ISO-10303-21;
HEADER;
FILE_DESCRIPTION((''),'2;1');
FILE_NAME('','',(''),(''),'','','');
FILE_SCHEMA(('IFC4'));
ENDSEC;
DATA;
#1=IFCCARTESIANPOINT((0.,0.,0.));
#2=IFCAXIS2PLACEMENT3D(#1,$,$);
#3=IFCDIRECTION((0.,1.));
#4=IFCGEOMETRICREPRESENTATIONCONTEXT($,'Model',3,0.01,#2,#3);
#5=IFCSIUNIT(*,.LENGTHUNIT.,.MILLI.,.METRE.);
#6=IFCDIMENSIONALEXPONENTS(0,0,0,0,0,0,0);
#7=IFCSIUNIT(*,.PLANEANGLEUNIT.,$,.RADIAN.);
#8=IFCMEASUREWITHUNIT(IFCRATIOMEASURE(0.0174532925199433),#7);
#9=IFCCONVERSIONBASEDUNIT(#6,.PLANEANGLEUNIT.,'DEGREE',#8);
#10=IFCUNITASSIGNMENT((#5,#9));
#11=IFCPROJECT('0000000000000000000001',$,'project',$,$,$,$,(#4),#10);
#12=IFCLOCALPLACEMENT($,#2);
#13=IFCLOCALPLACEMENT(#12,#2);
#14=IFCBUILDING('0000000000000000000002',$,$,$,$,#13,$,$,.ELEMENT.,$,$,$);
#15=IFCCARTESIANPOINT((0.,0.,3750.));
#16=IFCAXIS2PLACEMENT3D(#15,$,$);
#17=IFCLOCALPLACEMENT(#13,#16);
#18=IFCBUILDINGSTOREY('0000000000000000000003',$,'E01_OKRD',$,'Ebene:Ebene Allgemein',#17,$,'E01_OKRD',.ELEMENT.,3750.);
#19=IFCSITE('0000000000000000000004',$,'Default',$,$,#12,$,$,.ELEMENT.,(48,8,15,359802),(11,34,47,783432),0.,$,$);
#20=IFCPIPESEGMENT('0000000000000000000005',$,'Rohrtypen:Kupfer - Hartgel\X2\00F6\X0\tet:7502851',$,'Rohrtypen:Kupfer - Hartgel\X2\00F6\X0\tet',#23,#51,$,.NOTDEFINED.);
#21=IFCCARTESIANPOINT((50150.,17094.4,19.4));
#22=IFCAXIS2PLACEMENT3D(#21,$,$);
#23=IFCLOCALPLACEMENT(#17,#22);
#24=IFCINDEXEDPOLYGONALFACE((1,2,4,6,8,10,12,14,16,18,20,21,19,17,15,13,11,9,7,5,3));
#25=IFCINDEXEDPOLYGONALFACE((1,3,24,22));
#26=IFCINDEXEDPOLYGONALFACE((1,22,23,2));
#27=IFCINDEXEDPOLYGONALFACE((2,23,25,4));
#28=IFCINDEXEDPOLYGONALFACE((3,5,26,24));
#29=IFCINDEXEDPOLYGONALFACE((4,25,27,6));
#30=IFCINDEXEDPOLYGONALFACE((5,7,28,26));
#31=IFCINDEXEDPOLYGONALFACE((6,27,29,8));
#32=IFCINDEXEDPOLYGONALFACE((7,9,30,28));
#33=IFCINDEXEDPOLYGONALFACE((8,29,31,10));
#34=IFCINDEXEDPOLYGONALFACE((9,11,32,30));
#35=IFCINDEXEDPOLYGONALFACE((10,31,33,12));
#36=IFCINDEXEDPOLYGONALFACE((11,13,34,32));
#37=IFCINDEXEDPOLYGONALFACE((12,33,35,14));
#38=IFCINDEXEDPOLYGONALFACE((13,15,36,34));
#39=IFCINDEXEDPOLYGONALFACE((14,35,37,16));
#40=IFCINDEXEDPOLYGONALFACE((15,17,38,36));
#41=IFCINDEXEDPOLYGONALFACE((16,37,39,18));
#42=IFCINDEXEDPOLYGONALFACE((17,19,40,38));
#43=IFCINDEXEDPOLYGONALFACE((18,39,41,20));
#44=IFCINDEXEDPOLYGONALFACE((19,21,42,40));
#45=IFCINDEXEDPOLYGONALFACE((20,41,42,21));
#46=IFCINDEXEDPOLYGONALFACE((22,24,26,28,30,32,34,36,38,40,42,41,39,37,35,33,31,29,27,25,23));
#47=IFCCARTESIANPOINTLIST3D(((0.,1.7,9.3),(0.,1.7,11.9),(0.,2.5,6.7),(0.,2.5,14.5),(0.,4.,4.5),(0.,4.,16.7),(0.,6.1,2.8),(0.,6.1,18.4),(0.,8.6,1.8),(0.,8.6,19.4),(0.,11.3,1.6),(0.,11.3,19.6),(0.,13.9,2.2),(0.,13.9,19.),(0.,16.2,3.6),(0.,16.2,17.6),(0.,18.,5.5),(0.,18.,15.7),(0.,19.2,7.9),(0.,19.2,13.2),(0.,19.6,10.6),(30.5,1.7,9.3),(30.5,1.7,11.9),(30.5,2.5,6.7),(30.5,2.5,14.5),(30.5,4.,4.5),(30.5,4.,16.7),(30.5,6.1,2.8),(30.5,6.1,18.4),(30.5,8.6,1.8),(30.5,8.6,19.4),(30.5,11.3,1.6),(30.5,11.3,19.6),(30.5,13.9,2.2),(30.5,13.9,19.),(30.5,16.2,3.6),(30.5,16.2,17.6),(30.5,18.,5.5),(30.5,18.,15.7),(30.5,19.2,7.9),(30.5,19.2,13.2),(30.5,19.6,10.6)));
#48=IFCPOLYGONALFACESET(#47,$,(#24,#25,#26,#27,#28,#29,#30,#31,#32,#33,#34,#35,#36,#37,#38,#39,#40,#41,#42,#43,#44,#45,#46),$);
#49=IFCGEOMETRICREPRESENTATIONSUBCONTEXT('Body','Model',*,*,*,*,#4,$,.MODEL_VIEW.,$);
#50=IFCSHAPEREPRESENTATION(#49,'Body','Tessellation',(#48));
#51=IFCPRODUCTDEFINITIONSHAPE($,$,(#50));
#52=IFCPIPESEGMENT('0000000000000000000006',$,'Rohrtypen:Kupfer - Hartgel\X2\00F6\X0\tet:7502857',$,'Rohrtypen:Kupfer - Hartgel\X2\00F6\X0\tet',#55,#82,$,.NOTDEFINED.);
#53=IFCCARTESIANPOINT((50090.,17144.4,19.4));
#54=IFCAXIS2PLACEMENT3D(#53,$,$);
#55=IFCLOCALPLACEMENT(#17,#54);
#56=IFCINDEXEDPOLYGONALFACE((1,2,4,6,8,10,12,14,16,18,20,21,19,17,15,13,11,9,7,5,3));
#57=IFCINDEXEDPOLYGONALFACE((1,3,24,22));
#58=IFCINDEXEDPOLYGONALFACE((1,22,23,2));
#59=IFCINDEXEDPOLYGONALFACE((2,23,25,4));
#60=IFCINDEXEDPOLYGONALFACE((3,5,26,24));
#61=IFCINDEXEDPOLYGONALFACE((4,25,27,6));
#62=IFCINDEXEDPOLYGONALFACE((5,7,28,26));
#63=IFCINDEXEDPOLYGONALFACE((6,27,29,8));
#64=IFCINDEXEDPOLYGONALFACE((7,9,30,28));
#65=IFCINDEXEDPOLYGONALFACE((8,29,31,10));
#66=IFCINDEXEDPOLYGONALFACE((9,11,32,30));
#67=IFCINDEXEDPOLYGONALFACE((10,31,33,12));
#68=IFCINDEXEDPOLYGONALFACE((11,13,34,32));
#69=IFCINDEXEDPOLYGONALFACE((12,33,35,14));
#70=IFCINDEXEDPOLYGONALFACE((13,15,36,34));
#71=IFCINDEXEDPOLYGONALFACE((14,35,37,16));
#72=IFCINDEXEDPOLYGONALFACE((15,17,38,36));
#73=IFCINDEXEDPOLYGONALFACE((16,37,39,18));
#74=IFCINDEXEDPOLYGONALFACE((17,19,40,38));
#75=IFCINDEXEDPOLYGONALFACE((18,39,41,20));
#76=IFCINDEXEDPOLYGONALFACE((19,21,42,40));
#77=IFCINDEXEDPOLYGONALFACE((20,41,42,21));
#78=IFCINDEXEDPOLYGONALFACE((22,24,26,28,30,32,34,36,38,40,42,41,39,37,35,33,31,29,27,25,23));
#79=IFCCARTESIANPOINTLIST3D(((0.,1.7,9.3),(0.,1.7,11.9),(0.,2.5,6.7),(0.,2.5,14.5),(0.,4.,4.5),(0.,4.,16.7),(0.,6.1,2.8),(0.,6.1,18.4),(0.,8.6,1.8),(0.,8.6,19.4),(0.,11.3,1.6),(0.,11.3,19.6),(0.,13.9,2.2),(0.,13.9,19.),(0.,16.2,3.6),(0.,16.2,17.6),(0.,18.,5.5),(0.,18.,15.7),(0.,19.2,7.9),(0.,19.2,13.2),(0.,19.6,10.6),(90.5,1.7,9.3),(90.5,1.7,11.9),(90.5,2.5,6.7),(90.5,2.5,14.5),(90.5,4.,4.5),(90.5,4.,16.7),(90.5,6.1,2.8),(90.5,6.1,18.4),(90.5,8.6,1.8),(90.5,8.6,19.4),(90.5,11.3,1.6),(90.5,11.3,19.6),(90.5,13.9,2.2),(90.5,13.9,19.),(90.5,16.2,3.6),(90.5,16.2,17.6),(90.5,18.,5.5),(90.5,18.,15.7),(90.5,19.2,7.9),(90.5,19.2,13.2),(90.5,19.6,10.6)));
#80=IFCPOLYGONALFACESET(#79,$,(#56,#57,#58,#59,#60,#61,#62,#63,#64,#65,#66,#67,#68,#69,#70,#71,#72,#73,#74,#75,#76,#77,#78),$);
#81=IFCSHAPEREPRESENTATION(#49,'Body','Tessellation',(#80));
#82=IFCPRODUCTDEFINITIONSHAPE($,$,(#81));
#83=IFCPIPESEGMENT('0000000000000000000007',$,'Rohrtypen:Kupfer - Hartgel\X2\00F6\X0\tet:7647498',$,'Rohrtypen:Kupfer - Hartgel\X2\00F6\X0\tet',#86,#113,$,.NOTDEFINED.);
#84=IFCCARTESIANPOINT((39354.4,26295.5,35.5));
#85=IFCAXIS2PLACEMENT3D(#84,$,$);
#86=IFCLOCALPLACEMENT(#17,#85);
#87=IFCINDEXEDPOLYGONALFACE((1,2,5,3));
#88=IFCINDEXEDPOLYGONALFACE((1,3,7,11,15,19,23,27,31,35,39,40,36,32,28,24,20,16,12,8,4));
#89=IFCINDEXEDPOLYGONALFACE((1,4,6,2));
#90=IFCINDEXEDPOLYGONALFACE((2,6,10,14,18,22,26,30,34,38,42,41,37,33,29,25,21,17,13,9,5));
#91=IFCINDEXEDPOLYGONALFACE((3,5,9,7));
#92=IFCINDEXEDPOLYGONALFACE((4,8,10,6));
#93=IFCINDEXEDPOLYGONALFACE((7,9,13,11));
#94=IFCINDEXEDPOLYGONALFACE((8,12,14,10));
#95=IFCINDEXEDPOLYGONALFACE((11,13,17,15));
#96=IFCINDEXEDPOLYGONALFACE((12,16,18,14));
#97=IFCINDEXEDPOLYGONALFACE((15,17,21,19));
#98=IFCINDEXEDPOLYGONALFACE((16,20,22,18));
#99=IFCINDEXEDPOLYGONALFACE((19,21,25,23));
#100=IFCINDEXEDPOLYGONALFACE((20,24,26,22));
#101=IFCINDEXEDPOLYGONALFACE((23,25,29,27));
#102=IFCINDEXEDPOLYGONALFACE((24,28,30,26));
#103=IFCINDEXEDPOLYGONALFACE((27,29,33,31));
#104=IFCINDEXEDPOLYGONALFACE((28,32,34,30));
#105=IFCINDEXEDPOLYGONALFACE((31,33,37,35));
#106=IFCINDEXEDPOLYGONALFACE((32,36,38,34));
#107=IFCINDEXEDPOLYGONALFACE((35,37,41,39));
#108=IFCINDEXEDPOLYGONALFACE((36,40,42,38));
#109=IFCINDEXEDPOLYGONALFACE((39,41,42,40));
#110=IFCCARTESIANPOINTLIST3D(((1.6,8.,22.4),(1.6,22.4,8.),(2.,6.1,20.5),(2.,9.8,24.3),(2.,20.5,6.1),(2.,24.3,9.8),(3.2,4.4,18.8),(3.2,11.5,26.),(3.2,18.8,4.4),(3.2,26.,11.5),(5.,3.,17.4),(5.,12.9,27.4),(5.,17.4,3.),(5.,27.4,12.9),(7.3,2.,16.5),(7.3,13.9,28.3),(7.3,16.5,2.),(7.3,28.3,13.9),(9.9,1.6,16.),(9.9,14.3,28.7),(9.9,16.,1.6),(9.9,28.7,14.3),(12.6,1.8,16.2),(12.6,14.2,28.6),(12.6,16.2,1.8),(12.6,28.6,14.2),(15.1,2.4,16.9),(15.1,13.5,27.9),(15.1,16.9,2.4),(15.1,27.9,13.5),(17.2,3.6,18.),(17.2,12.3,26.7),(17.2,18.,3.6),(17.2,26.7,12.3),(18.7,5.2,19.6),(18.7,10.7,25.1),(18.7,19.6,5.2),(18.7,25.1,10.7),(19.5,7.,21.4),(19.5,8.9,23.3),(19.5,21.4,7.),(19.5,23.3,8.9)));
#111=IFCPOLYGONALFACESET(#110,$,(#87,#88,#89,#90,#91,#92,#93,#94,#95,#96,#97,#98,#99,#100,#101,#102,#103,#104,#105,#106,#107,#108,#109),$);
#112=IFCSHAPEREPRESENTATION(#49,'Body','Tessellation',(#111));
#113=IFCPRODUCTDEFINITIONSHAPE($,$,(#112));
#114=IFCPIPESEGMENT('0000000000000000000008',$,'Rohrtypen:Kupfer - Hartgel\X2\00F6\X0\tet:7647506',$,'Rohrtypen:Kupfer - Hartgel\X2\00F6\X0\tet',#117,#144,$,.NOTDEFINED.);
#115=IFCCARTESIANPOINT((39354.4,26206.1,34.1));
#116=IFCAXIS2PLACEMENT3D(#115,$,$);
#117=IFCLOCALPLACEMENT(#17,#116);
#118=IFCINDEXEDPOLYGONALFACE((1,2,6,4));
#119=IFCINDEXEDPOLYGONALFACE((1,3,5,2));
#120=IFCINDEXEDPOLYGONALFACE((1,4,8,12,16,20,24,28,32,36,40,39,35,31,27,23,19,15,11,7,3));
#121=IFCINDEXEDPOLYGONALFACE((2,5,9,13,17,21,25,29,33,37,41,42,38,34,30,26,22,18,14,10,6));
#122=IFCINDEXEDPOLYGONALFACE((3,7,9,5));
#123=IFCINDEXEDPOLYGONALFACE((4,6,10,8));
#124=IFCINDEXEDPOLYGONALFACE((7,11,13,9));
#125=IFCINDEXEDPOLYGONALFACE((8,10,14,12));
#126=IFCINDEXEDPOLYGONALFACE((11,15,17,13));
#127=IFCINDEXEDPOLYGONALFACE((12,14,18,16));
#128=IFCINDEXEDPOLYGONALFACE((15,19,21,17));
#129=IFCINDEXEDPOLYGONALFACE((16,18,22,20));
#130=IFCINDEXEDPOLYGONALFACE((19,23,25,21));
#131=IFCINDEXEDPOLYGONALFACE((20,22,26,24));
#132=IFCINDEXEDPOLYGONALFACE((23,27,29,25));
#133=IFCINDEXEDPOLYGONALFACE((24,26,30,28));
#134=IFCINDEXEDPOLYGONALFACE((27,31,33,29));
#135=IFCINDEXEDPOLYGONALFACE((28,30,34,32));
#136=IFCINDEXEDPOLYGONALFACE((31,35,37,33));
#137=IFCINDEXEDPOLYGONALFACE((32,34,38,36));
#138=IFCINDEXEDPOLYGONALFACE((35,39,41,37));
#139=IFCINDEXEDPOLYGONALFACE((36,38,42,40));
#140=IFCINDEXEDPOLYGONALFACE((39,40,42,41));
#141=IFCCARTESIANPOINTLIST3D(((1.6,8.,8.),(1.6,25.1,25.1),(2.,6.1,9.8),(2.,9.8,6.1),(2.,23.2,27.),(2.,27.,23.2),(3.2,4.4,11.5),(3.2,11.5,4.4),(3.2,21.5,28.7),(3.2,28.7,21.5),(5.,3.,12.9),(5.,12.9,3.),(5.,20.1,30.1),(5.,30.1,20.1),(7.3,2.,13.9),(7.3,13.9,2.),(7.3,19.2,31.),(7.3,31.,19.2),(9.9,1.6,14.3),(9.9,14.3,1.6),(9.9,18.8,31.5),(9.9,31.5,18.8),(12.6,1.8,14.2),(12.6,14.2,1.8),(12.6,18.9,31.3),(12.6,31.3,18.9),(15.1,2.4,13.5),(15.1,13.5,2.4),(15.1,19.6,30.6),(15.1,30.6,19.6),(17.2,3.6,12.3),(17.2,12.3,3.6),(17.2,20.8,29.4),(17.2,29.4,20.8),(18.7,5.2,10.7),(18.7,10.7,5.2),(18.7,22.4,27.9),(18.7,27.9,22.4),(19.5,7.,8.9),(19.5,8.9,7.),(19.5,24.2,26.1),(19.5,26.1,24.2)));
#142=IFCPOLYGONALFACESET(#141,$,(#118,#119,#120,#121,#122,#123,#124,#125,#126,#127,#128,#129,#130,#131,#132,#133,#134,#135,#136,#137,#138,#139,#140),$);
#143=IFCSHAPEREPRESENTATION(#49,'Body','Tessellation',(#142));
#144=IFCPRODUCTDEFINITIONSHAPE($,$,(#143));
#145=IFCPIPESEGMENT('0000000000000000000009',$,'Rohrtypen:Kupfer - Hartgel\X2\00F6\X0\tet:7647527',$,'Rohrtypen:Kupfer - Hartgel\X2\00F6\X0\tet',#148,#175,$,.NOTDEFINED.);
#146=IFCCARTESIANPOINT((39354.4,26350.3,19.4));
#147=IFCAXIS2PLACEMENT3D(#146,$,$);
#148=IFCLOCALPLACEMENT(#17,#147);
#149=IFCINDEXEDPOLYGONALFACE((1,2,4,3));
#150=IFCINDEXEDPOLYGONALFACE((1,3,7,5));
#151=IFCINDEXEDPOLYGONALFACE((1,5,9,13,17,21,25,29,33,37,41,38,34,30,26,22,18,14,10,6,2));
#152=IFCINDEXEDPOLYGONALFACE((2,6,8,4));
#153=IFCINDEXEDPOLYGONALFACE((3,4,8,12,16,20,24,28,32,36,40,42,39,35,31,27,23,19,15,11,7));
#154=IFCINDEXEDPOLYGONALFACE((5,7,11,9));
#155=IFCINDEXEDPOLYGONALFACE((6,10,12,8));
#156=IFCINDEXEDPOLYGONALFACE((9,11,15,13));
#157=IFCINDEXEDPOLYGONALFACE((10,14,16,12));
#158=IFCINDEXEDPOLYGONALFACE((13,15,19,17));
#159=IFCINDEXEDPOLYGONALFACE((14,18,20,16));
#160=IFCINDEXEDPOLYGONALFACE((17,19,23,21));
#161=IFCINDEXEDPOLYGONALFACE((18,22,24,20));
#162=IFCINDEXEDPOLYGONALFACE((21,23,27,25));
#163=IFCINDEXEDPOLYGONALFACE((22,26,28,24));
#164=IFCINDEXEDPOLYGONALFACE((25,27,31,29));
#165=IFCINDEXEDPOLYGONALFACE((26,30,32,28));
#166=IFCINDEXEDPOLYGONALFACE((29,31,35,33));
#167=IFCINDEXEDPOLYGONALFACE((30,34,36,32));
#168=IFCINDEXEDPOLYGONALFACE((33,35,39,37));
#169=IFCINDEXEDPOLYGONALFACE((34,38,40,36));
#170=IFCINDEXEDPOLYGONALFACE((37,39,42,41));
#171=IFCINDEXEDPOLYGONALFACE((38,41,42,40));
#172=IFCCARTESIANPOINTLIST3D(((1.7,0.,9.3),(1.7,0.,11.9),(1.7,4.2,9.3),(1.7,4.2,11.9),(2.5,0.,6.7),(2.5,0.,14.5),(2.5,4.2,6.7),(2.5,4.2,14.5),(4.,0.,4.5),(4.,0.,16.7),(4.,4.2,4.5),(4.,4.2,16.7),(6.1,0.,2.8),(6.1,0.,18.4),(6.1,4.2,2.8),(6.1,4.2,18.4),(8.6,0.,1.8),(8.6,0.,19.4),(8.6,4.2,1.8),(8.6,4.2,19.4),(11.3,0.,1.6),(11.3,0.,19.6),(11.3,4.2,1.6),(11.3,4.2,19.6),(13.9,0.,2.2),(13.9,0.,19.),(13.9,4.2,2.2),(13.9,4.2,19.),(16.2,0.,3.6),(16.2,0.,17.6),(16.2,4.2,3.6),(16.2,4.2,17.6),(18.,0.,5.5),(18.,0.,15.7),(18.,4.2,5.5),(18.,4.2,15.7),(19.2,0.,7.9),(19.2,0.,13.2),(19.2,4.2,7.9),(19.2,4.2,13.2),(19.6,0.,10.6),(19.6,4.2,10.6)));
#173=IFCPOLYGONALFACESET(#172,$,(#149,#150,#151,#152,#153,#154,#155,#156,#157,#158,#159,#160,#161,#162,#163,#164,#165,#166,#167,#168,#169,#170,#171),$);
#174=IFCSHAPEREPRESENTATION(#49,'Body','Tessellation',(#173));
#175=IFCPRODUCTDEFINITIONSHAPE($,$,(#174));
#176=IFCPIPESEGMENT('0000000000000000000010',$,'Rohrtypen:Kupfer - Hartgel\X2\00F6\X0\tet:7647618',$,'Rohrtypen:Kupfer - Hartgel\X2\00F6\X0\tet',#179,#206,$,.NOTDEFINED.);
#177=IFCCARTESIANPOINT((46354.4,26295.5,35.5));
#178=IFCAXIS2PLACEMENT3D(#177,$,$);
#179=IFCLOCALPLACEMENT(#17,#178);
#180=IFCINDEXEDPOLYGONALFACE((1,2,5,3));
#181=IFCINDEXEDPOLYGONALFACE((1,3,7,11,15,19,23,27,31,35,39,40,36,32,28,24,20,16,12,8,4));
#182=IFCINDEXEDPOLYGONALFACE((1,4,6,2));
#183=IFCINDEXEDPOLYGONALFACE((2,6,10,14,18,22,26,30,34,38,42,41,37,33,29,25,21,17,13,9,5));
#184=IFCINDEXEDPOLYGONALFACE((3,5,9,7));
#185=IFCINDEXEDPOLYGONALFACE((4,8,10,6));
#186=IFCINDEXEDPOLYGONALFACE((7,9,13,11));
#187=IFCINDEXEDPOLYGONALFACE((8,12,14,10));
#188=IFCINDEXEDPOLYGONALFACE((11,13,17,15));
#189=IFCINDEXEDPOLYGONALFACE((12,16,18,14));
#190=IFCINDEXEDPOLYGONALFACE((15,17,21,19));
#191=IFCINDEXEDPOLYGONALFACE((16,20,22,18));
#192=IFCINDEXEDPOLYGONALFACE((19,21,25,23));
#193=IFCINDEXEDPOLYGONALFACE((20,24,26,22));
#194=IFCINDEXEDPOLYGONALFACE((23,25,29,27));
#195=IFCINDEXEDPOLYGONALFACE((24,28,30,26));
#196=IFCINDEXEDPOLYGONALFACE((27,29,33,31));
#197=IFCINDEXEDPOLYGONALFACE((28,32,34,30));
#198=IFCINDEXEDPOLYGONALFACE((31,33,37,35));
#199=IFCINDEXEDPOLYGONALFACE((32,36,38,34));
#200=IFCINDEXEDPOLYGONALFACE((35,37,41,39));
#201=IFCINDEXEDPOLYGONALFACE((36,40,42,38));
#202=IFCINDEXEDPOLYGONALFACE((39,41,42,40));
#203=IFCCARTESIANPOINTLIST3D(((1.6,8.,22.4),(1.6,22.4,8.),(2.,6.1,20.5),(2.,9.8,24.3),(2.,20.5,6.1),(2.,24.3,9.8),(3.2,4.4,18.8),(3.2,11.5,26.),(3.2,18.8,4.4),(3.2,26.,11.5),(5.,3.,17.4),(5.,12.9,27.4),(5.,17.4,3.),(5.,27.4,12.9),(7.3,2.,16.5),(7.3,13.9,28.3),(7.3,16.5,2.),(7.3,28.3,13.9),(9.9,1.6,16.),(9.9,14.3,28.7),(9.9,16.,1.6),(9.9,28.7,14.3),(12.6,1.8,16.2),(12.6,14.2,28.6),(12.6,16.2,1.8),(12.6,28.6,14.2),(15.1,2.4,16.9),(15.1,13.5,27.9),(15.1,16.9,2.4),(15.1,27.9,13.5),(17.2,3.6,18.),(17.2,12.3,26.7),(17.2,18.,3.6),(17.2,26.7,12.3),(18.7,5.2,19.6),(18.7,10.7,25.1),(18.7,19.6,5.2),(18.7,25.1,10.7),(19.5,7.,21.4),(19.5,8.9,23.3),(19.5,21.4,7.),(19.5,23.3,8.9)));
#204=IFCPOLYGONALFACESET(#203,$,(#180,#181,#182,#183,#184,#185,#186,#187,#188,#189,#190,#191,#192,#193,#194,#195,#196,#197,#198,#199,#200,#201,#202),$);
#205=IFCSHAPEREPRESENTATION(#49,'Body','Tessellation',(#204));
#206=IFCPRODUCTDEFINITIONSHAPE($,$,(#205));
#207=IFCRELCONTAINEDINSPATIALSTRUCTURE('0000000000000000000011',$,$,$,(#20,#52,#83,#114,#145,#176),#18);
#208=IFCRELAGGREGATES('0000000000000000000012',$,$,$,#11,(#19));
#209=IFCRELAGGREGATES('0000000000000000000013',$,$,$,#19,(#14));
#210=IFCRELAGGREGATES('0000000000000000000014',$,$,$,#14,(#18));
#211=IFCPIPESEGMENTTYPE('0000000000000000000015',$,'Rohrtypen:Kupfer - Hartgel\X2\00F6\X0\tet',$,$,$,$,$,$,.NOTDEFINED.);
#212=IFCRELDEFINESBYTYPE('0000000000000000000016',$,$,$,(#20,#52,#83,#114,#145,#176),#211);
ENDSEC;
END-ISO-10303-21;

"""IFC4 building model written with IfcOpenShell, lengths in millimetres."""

from ifc_helpers import new_model, entity, si_unit, converted_unit, direction, frame, frame_2d, origin, origin_2d_with_axis, place, context, subcontext, project, spatial, circle, extrude, type_object, element, save


model = new_model("IFC4")

# Units and contexts
model_context = context("Model", 3, precision=0.01, world=origin(), true_north=direction((0.0, 1.0)))
body_context = subcontext(model_context, "Body", "Model", "MODEL_VIEW")
ifc_project = project(units=[si_unit("LENGTHUNIT", "METRE", prefix="MILLI"), converted_unit("PLANEANGLEUNIT", "DEGREE", entity("IfcRatioMeasure", 0.0174532925199433), si_unit("PLANEANGLEUNIT", "RADIAN"), dimensions=[0, 0, 0, 0, 0, 0, 0])], contexts=[model_context])

# Site, building, storey
site_placement = place(None, origin())
site = spatial("IfcSite", under=ifc_project, at=site_placement, Name="Default", CompositionType="ELEMENT", RefLatitude=(48, 8, 15, 359802), RefLongitude=(11, 34, 47, 783432), RefElevation=0.0)
building_placement = place(site_placement, origin())
building = spatial("IfcBuilding", under=site, at=building_placement, CompositionType="ELEMENT")
storey_placement = place(building_placement, frame((0.0, 0.0, 3750.0)))
storey = spatial("IfcBuildingStorey", under=building, at=storey_placement, Name="E01_OKRD", ObjectType="Ebene:Ebene Allgemein", LongName="E01_OKRD", CompositionType="ELEMENT", Elevation=3750.0)

# Pipe segments
pipe_segment_type = type_object("IfcPipeSegmentType", Name="Rohrtypen:Kupfer - Hartgelötet", PredefinedType="NOTDEFINED")
pipe_segment_1_placement = place(storey_placement, frame((50150.0, 17094.4, 19.4)))
element("IfcPipeSegment", 1, at=pipe_segment_1_placement, inside=storey, type_object=pipe_segment_type, Name="Rohrtypen:Kupfer - Hartgelötet:7502851", ObjectType="Rohrtypen:Kupfer - Hartgelötet", PredefinedType="NOTDEFINED", context=body_context, shape_type="SweptSolid", body=[
    extrude(circle(Radius=9.0, at=origin_2d_with_axis()), frame((0.0, 10.6, 10.6), z_axis=(1.0, 0.0, 0.0), x_axis=(0.0, 1.0, 0.0)), (0.0, 0.0, 1.0), 30.5),
])
pipe_segment_2_placement = place(storey_placement, frame((50090.0, 17144.4, 19.4)))
element("IfcPipeSegment", 2, at=pipe_segment_2_placement, inside=storey, type_object=pipe_segment_type, Name="Rohrtypen:Kupfer - Hartgelötet:7502857", ObjectType="Rohrtypen:Kupfer - Hartgelötet", PredefinedType="NOTDEFINED", context=body_context, shape_type="SweptSolid", body=[
    extrude(circle(Radius=9.0, at=origin_2d_with_axis()), frame((0.0, 10.6, 10.6), z_axis=(1.0, 0.0, 0.0), x_axis=(0.0, 1.0, 0.0)), (0.0, 0.0, 1.0), 90.5),
])
pipe_segment_3_placement = place(storey_placement, frame((39354.4, 26295.5, 35.5)))
element("IfcPipeSegment", 3, at=pipe_segment_3_placement, inside=storey, type_object=pipe_segment_type, Name="Rohrtypen:Kupfer - Hartgelötet:7647498", ObjectType="Rohrtypen:Kupfer - Hartgelötet", PredefinedType="NOTDEFINED", context=body_context, shape_type="SweptSolid", body=[
    extrude(circle(Radius=9.0, at=origin_2d_with_axis()), frame((10.6, 22.4, 8.0), z_axis=(0.0, -0.707107, 0.707107), x_axis=(-1.0, 0.0, 0.0)), (0.0, 0.0, 1.0), 20.4),
])
pipe_segment_4_placement = place(storey_placement, frame((39354.4, 26206.1, 34.1)))
element("IfcPipeSegment", 4, at=pipe_segment_4_placement, inside=storey, type_object=pipe_segment_type, Name="Rohrtypen:Kupfer - Hartgelötet:7647506", ObjectType="Rohrtypen:Kupfer - Hartgelötet", PredefinedType="NOTDEFINED", context=body_context, shape_type="SweptSolid", body=[
    extrude(circle(Radius=9.0, at=frame_2d((0.0, 0.0), x_axis=(1.0, 0.0))), frame((10.6, 8.0, 8.0), z_axis=(0.0, 0.707107, 0.707107), x_axis=(-1.0, 0.0, 0.0)), (0.0, 0.0, 1.0), 24.3),
])
pipe_segment_5_placement = place(storey_placement, frame((39354.4, 26350.3, 19.4)))
element("IfcPipeSegment", 5, at=pipe_segment_5_placement, inside=storey, type_object=pipe_segment_type, Name="Rohrtypen:Kupfer - Hartgelötet:7647527", ObjectType="Rohrtypen:Kupfer - Hartgelötet", PredefinedType="NOTDEFINED", context=body_context, shape_type="SweptSolid", body=[
    extrude(circle(Radius=9.0, at=origin_2d_with_axis()), frame((10.6, 0.0, 10.6), z_axis=(0.0, 1.0, 0.0), x_axis=(1.0, 0.0, 0.0)), (0.0, 0.0, 1.0), 4.2),
])
pipe_segment_6_placement = place(storey_placement, frame((46354.4, 26295.5, 35.5)))
element("IfcPipeSegment", 6, at=pipe_segment_6_placement, inside=storey, type_object=pipe_segment_type, Name="Rohrtypen:Kupfer - Hartgelötet:7647618", ObjectType="Rohrtypen:Kupfer - Hartgelötet", PredefinedType="NOTDEFINED", context=body_context, shape_type="SweptSolid", body=[
    extrude(circle(Radius=9.0, at=origin_2d_with_axis()), frame((10.6, 22.4, 8.0), z_axis=(0.0, -0.707107, 0.707107), x_axis=(-1.0, 0.0, 0.0)), (0.0, 0.0, 1.0), 20.4),
])

save(model, "model.ifc")
